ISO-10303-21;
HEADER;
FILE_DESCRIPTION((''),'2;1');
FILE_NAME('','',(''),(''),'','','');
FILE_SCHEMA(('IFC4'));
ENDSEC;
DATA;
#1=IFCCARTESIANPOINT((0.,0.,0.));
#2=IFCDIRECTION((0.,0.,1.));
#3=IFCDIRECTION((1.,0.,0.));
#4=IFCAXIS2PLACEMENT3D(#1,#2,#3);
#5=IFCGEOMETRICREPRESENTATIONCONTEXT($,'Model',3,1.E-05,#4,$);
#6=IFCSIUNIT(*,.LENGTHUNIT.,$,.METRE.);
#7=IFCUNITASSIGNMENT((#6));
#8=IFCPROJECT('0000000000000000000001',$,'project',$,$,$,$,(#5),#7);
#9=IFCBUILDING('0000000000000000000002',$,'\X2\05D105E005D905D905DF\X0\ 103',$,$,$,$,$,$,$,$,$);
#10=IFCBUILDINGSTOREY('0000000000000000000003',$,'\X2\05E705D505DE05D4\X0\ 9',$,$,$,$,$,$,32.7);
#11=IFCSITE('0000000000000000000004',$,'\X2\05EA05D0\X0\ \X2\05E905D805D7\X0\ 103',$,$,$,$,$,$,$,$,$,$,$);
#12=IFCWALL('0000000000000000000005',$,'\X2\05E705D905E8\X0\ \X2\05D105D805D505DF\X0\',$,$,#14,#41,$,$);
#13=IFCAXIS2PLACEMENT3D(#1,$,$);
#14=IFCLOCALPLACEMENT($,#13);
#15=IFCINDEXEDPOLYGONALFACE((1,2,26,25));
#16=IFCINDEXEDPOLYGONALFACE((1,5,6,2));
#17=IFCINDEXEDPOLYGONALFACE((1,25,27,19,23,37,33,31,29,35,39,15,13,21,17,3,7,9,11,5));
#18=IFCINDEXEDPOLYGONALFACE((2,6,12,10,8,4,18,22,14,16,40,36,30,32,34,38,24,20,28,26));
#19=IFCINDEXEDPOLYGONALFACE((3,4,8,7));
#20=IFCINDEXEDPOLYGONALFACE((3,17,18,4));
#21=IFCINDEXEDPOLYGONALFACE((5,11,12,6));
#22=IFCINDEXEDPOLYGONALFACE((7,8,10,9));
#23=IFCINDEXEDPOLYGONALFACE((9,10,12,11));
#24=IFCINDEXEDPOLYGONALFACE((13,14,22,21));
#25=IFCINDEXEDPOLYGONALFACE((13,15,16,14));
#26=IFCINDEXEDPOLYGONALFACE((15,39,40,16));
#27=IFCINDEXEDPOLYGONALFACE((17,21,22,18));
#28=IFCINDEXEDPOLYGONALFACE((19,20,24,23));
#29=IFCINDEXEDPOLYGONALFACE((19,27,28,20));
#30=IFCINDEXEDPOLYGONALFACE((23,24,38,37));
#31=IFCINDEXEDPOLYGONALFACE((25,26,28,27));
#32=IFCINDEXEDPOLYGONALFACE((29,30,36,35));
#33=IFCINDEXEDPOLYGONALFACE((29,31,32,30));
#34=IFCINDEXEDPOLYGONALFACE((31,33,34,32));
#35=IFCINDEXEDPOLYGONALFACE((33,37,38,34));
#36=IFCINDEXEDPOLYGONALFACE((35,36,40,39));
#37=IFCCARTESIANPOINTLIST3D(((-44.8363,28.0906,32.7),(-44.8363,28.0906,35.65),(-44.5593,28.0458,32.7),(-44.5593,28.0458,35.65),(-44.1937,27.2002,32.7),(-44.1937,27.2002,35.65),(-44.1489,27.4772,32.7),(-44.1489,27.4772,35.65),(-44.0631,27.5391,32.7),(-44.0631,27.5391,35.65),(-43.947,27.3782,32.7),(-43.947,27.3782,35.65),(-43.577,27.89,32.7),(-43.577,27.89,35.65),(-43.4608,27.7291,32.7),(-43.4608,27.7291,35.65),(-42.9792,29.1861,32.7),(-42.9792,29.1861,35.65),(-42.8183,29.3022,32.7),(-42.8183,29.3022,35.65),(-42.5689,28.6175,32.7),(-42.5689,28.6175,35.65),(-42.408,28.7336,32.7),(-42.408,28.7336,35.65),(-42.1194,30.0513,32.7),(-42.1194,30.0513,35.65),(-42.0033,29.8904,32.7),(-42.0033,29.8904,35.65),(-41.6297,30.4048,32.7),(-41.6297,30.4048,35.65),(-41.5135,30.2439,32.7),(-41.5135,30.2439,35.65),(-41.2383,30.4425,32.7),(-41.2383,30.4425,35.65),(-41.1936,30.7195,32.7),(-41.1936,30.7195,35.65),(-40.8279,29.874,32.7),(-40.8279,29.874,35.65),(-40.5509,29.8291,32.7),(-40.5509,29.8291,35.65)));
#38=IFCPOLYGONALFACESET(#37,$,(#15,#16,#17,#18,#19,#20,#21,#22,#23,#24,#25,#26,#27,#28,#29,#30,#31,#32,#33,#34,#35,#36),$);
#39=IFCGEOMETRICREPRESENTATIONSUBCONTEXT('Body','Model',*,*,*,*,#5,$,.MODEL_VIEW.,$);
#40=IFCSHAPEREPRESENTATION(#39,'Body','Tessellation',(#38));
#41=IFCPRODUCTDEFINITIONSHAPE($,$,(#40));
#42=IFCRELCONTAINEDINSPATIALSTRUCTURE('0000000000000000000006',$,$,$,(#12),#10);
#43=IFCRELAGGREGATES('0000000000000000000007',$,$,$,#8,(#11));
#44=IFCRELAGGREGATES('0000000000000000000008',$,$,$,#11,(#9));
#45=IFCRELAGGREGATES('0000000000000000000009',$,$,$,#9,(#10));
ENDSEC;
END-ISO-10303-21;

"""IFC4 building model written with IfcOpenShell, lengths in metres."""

from ifc_helpers import new_model, si_unit, frame, origin_with_axes, context, subcontext, project, spatial, polyline, outline, extrude, element, save


model = new_model("IFC4")

# Units and contexts
model_context = context("Model", 3, precision=1e-05, world=origin_with_axes())
body_context = subcontext(model_context, "Body", "Model", "MODEL_VIEW")
ifc_project = project(units=[si_unit("LENGTHUNIT", "METRE")], contexts=[model_context])

# Site, building, storey
site = spatial("IfcSite", under=ifc_project, Name="תא שטח 103")
building = spatial("IfcBuilding", under=site, Name="בניין 103")
storey = spatial("IfcBuildingStorey", under=building, Name="קומה 9", Elevation=32.7)

# Wall
element("IfcWall", 1, inside=storey, Name="קיר בטון", context=body_context, shape_type="SweptSolid", body=[
    extrude(outline(polyline([(-43.947, 27.3782), (-44.1937, 27.2002), (-44.8363, 28.0906), (-42.1194, 30.0513), (-42.0033, 29.8904), (-42.8183, 29.3022), (-42.408, 28.7336), (-40.8279, 29.874), (-41.2383, 30.4425), (-41.5135, 30.2439), (-41.6297, 30.4048), (-41.1936, 30.7195), (-40.5509, 29.8291), (-43.4608, 27.7291), (-43.577, 27.89), (-42.5689, 28.6175), (-42.9792, 29.1861), (-44.5593, 28.0458), (-44.1489, 27.4772), (-44.0631, 27.5391), (-43.947, 27.3782)])), frame((0.0, 0.0, 32.7)), (0.0, 0.0, 1.0), 2.95),
])

save(model, "model.ifc")
